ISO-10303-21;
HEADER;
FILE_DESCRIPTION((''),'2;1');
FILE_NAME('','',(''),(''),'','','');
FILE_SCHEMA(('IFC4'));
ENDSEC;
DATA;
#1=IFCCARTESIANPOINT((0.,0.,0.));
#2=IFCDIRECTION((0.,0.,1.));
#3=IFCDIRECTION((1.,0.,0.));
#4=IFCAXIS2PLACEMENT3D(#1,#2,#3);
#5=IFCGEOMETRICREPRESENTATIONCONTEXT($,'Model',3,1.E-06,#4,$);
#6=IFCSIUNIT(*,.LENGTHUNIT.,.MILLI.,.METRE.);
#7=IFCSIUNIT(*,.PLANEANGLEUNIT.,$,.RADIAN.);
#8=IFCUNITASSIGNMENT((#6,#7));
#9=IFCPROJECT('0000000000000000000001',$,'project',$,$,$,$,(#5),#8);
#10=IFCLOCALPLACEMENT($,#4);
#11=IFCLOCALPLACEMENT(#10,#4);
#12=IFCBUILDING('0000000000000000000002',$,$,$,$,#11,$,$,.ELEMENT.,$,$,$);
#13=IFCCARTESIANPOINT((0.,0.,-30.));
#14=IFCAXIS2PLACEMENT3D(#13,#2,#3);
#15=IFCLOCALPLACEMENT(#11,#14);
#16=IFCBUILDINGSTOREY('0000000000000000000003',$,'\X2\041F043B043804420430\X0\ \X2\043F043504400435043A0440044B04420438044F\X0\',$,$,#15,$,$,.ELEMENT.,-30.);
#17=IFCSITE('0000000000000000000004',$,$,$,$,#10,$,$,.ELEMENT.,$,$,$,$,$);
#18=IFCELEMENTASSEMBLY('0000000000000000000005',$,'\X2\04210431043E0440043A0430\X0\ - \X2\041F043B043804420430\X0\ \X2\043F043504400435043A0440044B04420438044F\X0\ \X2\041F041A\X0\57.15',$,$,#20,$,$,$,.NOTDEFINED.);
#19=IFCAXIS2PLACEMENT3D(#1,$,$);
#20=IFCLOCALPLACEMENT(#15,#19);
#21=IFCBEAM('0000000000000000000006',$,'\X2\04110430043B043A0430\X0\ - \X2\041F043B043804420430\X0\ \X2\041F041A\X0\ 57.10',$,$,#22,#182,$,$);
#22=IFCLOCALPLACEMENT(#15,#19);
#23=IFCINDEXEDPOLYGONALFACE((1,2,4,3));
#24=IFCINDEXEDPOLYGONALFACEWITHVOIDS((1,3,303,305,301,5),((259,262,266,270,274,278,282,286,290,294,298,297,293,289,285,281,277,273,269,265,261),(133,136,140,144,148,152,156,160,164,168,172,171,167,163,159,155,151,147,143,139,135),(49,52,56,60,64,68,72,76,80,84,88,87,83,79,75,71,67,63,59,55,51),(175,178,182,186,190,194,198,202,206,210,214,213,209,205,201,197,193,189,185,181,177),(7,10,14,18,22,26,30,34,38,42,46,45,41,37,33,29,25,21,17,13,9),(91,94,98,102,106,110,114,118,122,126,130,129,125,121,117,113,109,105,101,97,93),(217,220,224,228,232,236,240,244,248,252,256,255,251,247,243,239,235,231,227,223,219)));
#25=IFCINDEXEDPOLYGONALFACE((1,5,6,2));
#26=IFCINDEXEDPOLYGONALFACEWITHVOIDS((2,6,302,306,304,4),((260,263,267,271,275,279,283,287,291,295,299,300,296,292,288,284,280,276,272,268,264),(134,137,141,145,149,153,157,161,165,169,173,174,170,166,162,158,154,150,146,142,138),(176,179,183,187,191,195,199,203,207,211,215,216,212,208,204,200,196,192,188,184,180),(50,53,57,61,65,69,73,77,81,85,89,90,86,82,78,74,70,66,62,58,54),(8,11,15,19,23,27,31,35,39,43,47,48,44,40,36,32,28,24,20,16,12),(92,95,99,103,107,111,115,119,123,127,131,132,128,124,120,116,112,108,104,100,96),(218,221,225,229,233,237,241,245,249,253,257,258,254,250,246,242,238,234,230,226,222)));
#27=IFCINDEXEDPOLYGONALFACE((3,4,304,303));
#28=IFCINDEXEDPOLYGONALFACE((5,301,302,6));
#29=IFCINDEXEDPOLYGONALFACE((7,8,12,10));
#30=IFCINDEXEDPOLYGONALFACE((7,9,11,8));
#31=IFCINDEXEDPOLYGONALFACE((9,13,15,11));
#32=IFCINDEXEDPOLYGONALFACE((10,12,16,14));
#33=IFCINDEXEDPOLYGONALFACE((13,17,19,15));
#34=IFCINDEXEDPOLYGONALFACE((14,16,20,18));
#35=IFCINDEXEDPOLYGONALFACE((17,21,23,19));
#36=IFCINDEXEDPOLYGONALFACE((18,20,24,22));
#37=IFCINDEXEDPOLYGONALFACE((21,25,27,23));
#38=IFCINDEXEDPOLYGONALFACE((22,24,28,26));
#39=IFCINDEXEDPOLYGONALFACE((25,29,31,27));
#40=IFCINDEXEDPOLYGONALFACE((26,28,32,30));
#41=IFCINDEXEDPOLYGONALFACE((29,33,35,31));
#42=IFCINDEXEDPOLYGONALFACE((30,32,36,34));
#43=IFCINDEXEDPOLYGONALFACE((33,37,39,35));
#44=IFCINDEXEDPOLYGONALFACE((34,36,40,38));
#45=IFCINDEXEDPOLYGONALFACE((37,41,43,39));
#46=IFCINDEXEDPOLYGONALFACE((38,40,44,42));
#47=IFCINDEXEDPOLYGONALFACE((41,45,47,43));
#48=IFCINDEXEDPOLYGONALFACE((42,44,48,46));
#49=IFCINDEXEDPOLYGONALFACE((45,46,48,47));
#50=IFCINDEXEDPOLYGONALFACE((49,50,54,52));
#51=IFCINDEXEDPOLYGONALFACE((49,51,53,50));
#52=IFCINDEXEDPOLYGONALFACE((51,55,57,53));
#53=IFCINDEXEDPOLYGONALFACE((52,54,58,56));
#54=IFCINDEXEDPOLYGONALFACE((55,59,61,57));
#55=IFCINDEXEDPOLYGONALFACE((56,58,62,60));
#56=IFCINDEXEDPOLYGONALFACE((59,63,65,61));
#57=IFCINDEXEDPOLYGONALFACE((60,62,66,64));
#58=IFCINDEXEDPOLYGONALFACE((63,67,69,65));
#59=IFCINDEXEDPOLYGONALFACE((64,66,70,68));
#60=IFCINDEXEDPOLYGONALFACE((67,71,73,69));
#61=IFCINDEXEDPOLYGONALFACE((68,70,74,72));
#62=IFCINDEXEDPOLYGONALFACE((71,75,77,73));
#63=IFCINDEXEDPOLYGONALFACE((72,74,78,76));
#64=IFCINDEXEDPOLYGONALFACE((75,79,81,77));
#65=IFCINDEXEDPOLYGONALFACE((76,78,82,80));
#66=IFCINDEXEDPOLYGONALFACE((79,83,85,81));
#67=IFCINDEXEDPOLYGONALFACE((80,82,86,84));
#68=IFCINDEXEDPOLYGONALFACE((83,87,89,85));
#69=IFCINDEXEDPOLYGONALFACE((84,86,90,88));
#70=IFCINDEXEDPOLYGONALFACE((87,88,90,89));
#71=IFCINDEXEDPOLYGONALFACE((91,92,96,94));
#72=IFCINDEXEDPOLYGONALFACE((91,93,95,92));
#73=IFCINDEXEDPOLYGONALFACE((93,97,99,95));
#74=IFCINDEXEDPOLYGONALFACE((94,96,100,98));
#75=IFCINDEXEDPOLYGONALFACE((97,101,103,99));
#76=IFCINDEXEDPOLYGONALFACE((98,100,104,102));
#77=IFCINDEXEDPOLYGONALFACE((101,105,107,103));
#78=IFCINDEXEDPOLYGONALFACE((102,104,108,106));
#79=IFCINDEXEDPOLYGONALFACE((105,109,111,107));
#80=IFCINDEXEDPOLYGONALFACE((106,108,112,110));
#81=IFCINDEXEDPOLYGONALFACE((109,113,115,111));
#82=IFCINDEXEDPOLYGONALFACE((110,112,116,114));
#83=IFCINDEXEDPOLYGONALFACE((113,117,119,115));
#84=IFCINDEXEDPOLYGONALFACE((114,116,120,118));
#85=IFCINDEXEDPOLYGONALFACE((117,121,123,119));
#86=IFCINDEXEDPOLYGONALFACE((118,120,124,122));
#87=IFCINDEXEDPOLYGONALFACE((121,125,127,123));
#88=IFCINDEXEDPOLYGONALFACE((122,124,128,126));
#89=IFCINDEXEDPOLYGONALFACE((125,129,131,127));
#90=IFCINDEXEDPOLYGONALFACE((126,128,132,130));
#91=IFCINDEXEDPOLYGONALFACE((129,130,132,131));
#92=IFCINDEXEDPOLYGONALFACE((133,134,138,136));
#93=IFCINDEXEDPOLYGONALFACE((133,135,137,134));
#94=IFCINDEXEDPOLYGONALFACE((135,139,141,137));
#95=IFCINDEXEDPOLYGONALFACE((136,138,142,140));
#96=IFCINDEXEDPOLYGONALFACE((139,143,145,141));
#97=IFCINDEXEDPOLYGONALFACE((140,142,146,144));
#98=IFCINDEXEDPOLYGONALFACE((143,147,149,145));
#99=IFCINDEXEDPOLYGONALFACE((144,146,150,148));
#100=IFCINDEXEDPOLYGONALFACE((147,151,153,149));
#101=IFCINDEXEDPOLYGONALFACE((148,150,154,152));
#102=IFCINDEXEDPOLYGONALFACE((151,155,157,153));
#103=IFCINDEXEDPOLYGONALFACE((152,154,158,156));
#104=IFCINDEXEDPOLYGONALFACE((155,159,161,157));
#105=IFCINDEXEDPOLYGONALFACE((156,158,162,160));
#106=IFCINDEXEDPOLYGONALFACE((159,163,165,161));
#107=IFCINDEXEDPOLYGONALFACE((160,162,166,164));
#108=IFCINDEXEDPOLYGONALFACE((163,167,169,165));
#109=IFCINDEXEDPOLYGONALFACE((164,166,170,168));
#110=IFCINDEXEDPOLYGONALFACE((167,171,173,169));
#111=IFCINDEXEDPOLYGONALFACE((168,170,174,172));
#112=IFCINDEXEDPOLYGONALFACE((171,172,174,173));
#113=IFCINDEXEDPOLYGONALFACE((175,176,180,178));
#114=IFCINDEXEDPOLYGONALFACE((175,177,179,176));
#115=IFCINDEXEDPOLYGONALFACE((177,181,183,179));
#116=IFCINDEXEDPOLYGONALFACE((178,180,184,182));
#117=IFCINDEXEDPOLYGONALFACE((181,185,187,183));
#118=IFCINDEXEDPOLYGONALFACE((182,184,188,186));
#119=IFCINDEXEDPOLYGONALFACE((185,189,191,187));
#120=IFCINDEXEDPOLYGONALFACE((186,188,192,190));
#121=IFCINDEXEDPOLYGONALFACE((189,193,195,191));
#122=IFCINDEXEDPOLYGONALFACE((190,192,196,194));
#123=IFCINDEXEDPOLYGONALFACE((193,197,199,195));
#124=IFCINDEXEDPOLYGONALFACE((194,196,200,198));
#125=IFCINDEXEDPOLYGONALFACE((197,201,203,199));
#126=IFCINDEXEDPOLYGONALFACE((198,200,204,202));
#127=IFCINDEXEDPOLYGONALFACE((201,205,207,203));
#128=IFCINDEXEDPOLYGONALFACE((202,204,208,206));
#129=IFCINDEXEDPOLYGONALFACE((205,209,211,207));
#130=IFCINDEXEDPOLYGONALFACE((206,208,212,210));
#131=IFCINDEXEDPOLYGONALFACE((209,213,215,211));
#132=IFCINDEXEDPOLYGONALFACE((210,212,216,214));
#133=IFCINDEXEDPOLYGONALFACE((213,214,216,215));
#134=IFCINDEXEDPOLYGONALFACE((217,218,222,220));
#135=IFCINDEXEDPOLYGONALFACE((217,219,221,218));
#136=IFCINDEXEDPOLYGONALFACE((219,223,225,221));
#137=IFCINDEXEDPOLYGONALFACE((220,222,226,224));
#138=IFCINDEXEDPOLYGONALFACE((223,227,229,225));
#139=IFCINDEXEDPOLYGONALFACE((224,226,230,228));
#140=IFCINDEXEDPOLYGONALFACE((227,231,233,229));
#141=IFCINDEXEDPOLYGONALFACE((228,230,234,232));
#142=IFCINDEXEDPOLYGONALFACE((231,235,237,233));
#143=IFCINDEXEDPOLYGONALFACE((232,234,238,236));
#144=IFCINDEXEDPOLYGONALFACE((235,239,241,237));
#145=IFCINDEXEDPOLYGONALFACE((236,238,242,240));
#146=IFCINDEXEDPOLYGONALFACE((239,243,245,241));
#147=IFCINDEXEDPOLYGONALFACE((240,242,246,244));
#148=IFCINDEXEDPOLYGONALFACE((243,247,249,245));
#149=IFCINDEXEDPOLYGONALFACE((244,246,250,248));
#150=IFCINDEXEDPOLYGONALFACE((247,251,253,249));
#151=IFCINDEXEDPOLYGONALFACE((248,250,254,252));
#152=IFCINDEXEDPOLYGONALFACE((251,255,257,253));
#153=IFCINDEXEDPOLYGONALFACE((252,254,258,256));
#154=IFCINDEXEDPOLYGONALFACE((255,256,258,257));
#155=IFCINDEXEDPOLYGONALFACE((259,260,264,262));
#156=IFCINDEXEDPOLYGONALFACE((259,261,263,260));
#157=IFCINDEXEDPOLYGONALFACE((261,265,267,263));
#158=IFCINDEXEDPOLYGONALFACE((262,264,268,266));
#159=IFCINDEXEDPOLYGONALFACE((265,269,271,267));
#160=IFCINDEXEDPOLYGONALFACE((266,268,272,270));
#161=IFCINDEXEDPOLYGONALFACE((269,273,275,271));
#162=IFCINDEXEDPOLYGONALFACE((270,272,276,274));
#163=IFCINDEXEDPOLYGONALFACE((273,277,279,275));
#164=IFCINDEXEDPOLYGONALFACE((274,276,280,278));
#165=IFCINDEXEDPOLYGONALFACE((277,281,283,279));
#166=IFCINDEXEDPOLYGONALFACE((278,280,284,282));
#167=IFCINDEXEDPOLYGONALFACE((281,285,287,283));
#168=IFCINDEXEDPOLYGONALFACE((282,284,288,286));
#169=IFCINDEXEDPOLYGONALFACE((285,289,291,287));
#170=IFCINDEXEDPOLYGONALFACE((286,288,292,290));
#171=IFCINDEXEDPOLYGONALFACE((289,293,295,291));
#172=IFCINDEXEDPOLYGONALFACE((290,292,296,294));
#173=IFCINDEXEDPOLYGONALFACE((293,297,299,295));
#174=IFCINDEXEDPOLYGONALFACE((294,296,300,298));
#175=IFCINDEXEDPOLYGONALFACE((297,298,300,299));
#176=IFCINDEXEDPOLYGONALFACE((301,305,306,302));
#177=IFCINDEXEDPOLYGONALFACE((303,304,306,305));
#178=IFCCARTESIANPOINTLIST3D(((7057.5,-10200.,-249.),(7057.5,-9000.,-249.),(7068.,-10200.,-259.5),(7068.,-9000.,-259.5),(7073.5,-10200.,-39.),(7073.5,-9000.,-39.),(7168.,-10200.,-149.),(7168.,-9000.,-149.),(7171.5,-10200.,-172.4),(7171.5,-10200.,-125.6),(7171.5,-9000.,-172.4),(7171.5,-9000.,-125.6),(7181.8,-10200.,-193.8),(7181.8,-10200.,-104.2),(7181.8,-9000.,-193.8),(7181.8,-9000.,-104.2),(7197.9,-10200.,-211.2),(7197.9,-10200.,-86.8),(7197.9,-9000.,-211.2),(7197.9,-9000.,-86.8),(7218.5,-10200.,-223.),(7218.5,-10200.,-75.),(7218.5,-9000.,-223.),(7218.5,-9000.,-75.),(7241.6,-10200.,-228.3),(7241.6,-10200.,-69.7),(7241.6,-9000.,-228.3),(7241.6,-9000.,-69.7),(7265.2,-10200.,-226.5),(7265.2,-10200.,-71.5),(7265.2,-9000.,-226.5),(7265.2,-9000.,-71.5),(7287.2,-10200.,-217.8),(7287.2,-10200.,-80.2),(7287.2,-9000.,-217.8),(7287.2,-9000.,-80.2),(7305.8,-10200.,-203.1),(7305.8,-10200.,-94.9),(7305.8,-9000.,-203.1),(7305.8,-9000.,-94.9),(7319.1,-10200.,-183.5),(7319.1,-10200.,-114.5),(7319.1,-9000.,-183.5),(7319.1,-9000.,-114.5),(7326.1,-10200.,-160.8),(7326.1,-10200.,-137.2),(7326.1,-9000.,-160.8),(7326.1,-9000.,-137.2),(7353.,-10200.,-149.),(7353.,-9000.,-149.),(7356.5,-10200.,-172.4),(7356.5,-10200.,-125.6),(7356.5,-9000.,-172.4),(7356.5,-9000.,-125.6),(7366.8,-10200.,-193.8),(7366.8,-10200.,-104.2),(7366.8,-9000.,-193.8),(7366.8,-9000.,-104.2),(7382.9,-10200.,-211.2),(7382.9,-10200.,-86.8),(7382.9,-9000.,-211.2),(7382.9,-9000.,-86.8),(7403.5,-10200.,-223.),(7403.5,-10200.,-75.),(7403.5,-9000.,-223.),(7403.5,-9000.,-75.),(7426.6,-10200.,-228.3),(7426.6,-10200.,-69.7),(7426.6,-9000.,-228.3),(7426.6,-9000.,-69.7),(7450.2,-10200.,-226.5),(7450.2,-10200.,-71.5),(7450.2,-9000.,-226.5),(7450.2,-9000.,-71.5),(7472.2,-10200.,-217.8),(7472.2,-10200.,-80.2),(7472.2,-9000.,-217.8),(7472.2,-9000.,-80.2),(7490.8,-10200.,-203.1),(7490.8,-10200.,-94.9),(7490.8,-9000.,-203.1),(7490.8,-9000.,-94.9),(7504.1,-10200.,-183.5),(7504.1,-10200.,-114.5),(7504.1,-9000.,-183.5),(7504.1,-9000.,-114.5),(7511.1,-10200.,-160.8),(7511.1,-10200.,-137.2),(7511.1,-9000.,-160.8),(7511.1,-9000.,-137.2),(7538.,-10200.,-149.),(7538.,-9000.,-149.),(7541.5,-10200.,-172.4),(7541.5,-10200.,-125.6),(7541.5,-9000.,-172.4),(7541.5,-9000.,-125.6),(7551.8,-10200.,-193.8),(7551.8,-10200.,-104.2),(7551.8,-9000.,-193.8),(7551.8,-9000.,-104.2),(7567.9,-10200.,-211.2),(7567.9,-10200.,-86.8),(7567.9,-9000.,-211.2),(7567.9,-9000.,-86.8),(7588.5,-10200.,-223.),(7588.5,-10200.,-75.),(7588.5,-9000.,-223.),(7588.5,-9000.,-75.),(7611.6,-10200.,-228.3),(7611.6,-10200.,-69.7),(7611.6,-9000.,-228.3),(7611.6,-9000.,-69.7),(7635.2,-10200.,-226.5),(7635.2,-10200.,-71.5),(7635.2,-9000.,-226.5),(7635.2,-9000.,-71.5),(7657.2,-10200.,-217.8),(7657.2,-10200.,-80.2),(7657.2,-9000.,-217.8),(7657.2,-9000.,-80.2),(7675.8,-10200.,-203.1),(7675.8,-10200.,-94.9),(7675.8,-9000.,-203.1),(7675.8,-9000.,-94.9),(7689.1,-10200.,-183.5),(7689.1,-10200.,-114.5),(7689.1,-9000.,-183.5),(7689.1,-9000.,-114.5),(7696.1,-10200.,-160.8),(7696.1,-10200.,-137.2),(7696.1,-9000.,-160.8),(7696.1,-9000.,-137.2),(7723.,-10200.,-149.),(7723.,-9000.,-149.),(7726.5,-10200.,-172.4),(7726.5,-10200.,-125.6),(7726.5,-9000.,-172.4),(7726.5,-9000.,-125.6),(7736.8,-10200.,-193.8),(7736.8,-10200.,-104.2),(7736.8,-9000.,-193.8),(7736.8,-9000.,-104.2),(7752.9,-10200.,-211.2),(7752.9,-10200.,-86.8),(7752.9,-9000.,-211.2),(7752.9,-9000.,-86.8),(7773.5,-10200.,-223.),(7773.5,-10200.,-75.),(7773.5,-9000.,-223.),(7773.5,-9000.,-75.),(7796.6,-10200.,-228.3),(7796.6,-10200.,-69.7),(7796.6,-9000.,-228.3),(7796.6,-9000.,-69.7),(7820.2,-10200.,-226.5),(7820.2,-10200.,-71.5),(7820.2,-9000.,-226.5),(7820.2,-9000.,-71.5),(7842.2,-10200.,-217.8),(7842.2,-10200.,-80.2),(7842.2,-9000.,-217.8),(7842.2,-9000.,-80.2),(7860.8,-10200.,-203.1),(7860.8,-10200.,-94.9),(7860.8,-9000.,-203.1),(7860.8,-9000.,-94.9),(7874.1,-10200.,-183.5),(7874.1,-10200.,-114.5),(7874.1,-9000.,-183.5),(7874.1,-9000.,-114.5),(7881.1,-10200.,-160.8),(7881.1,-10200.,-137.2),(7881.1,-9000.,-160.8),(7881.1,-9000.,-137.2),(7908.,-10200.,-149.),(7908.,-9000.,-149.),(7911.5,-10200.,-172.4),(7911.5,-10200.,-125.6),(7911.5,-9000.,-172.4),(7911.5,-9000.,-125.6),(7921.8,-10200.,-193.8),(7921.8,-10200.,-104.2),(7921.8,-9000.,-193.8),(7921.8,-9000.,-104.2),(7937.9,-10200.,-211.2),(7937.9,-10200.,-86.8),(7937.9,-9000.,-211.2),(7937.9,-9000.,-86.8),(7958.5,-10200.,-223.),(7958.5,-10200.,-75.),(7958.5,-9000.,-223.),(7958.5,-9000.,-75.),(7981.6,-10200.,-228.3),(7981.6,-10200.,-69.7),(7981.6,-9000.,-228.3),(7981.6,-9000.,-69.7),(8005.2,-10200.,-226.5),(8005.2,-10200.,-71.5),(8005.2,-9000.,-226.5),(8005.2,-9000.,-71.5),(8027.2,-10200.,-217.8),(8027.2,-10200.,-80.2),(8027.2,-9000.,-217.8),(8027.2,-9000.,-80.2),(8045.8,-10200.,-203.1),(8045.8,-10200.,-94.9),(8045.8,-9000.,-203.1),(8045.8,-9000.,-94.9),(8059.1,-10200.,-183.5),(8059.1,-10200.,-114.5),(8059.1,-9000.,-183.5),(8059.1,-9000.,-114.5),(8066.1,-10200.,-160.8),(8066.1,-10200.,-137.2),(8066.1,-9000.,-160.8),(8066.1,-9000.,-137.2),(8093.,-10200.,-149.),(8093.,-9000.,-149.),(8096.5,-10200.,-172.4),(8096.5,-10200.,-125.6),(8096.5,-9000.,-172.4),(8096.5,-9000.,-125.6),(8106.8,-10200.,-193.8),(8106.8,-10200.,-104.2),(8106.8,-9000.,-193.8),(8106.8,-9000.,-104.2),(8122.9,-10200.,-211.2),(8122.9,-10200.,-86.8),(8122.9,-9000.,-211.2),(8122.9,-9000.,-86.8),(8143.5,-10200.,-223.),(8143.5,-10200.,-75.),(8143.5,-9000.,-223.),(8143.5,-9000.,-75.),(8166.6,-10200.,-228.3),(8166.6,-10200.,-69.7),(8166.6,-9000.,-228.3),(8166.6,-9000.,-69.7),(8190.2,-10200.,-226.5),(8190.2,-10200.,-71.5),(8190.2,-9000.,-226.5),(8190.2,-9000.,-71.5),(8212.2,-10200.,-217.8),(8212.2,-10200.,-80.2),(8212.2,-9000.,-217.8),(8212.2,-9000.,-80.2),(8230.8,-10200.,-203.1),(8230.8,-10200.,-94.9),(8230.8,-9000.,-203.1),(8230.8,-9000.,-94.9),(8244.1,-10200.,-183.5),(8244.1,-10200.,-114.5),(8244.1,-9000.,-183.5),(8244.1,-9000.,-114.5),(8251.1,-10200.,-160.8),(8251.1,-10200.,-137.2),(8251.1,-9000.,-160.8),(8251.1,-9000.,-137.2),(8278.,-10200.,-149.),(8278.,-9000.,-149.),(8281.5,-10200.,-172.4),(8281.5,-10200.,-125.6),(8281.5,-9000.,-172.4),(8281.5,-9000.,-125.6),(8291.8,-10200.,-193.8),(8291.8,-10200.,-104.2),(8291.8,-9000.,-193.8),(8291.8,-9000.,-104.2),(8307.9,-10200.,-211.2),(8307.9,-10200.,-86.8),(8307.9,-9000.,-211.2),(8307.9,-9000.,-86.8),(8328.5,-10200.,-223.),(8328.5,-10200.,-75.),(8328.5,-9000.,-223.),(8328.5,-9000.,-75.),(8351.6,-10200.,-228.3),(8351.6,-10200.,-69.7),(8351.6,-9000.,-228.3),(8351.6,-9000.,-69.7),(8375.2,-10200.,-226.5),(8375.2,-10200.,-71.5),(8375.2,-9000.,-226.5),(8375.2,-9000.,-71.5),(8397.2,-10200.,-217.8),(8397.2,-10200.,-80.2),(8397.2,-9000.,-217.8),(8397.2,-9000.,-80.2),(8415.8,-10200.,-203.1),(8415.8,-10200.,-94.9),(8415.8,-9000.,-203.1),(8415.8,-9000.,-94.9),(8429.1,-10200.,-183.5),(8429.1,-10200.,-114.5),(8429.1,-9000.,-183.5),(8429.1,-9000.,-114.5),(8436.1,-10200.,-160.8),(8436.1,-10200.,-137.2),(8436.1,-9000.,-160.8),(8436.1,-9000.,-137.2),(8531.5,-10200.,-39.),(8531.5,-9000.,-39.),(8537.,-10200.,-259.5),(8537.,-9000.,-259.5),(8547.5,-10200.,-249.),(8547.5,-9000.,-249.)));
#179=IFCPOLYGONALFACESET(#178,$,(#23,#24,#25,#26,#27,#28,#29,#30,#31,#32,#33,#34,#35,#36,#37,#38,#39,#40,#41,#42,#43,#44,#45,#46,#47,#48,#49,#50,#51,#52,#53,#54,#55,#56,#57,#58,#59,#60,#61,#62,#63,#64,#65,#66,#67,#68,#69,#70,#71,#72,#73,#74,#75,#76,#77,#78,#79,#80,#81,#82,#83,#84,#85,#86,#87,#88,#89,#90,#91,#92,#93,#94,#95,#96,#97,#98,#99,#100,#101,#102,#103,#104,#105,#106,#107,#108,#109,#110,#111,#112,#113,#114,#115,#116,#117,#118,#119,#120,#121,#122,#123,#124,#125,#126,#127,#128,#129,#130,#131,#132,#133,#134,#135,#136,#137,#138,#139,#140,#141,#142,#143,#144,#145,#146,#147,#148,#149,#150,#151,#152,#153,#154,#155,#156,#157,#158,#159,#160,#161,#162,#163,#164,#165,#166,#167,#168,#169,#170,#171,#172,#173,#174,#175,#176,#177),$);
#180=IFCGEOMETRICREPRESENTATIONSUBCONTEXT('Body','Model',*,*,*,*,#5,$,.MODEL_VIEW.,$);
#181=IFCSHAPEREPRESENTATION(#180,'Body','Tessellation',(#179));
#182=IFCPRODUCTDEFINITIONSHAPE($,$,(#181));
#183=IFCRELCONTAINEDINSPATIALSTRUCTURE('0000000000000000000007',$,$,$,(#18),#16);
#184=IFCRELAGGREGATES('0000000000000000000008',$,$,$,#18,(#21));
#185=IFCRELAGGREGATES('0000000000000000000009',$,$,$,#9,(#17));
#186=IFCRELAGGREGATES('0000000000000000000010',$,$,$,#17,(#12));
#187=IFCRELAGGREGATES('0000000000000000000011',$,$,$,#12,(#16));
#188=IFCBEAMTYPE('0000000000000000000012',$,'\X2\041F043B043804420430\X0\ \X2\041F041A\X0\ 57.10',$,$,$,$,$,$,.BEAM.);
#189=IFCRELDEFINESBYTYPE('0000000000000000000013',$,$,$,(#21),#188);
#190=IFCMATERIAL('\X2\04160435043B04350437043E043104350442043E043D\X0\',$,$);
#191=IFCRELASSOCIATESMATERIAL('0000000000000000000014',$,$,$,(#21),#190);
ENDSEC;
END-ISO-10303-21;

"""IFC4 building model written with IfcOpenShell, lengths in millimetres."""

from ifc_helpers import new_model, si_unit, frame, frame_2d, origin_with_axes, place, context, subcontext, project, spatial, line, indexed_curve, circle_curve, outline, extrude, material, type_object, element, aggregate, save


model = new_model("IFC4")

# Units and contexts
model_context = context("Model", 3, precision=1e-06, world=origin_with_axes())
body_context = subcontext(model_context, "Body", "Model", "MODEL_VIEW")
ifc_project = project(units=[si_unit("LENGTHUNIT", "METRE", prefix="MILLI"), si_unit("PLANEANGLEUNIT", "RADIAN")], contexts=[model_context])

# Site, building, storey
site_placement = place(None, origin_with_axes())
site = spatial("IfcSite", under=ifc_project, at=site_placement, CompositionType="ELEMENT")
building_placement = place(site_placement, origin_with_axes())
building = spatial("IfcBuilding", under=site, at=building_placement, CompositionType="ELEMENT")
storey_placement = place(building_placement, frame((0.0, 0.0, -30.0), z_axis=(0.0, 0.0, 1.0), x_axis=(1.0, 0.0, 0.0)))
storey = spatial("IfcBuildingStorey", under=building, at=storey_placement, Name="Плита перекрытия", CompositionType="ELEMENT", Elevation=-30.0)

# Element assembly, beam
ifc_material_1 = material(Name="Железобетон")
beam_type_1 = type_object("IfcBeamType", Name="Плита ПК 57.10", PredefinedType="BEAM")
assembly_1_placement = place(storey_placement, frame((7802.5, -9750.0, -39.0), z_axis=(0.0, 0.0, 1.0), x_axis=(1.0, 0.0, 0.0)))
assembly_1 = element("IfcElementAssembly", 1, at=assembly_1_placement, inside=storey, Name="Сборка - Плита перекрытия ПК57.15", PredefinedType="NOTDEFINED")
beam_1_placement = place(assembly_1_placement, frame((0.0, 750.0, 0.0), z_axis=(0.0, 1.0, 0.0), x_axis=(-1.0, 0.0, 0.0)))
beam_1 = element("IfcBeam", 2, at=beam_1_placement, type_object=beam_type_1, material=ifc_material_1, Name="Балка - Плита ПК 57.10", context=body_context, shape_type="SweptSolid", body=[
    extrude(outline(indexed_curve([(-729.0, 0.0), (-745.0, -210.0), (-734.5, -220.5), (734.5, -220.5), (745.0, -210.0), (729.0, 0.0)], segments=[line(1, 2), line(2, 3), line(3, 4), line(4, 5), line(5, 6), line(6, 1)]), holes=[circle_curve(frame_2d((555.0, -110.0), x_axis=(1.0, 0.0)), 79.5), circle_curve(frame_2d((370.0, -110.0), x_axis=(1.0, 0.0)), 79.5), circle_curve(frame_2d((185.0, -110.0), x_axis=(1.0, 0.0)), 79.5), circle_curve(frame_2d((-555.0, -110.0), x_axis=(1.0, 0.0)), 79.5), circle_curve(frame_2d((-370.0, -110.0), x_axis=(1.0, 0.0)), 79.5), circle_curve(frame_2d((-185.0, -110.0), x_axis=(1.0, 0.0)), 79.5), circle_curve(frame_2d((0.0, -110.0), x_axis=(1.0, 0.0)), 79.5)]), origin_with_axes(), (0.0, 0.0, -1.0), 1200.0),
])
aggregate(assembly_1, [beam_1])

save(model, "model.ifc")
